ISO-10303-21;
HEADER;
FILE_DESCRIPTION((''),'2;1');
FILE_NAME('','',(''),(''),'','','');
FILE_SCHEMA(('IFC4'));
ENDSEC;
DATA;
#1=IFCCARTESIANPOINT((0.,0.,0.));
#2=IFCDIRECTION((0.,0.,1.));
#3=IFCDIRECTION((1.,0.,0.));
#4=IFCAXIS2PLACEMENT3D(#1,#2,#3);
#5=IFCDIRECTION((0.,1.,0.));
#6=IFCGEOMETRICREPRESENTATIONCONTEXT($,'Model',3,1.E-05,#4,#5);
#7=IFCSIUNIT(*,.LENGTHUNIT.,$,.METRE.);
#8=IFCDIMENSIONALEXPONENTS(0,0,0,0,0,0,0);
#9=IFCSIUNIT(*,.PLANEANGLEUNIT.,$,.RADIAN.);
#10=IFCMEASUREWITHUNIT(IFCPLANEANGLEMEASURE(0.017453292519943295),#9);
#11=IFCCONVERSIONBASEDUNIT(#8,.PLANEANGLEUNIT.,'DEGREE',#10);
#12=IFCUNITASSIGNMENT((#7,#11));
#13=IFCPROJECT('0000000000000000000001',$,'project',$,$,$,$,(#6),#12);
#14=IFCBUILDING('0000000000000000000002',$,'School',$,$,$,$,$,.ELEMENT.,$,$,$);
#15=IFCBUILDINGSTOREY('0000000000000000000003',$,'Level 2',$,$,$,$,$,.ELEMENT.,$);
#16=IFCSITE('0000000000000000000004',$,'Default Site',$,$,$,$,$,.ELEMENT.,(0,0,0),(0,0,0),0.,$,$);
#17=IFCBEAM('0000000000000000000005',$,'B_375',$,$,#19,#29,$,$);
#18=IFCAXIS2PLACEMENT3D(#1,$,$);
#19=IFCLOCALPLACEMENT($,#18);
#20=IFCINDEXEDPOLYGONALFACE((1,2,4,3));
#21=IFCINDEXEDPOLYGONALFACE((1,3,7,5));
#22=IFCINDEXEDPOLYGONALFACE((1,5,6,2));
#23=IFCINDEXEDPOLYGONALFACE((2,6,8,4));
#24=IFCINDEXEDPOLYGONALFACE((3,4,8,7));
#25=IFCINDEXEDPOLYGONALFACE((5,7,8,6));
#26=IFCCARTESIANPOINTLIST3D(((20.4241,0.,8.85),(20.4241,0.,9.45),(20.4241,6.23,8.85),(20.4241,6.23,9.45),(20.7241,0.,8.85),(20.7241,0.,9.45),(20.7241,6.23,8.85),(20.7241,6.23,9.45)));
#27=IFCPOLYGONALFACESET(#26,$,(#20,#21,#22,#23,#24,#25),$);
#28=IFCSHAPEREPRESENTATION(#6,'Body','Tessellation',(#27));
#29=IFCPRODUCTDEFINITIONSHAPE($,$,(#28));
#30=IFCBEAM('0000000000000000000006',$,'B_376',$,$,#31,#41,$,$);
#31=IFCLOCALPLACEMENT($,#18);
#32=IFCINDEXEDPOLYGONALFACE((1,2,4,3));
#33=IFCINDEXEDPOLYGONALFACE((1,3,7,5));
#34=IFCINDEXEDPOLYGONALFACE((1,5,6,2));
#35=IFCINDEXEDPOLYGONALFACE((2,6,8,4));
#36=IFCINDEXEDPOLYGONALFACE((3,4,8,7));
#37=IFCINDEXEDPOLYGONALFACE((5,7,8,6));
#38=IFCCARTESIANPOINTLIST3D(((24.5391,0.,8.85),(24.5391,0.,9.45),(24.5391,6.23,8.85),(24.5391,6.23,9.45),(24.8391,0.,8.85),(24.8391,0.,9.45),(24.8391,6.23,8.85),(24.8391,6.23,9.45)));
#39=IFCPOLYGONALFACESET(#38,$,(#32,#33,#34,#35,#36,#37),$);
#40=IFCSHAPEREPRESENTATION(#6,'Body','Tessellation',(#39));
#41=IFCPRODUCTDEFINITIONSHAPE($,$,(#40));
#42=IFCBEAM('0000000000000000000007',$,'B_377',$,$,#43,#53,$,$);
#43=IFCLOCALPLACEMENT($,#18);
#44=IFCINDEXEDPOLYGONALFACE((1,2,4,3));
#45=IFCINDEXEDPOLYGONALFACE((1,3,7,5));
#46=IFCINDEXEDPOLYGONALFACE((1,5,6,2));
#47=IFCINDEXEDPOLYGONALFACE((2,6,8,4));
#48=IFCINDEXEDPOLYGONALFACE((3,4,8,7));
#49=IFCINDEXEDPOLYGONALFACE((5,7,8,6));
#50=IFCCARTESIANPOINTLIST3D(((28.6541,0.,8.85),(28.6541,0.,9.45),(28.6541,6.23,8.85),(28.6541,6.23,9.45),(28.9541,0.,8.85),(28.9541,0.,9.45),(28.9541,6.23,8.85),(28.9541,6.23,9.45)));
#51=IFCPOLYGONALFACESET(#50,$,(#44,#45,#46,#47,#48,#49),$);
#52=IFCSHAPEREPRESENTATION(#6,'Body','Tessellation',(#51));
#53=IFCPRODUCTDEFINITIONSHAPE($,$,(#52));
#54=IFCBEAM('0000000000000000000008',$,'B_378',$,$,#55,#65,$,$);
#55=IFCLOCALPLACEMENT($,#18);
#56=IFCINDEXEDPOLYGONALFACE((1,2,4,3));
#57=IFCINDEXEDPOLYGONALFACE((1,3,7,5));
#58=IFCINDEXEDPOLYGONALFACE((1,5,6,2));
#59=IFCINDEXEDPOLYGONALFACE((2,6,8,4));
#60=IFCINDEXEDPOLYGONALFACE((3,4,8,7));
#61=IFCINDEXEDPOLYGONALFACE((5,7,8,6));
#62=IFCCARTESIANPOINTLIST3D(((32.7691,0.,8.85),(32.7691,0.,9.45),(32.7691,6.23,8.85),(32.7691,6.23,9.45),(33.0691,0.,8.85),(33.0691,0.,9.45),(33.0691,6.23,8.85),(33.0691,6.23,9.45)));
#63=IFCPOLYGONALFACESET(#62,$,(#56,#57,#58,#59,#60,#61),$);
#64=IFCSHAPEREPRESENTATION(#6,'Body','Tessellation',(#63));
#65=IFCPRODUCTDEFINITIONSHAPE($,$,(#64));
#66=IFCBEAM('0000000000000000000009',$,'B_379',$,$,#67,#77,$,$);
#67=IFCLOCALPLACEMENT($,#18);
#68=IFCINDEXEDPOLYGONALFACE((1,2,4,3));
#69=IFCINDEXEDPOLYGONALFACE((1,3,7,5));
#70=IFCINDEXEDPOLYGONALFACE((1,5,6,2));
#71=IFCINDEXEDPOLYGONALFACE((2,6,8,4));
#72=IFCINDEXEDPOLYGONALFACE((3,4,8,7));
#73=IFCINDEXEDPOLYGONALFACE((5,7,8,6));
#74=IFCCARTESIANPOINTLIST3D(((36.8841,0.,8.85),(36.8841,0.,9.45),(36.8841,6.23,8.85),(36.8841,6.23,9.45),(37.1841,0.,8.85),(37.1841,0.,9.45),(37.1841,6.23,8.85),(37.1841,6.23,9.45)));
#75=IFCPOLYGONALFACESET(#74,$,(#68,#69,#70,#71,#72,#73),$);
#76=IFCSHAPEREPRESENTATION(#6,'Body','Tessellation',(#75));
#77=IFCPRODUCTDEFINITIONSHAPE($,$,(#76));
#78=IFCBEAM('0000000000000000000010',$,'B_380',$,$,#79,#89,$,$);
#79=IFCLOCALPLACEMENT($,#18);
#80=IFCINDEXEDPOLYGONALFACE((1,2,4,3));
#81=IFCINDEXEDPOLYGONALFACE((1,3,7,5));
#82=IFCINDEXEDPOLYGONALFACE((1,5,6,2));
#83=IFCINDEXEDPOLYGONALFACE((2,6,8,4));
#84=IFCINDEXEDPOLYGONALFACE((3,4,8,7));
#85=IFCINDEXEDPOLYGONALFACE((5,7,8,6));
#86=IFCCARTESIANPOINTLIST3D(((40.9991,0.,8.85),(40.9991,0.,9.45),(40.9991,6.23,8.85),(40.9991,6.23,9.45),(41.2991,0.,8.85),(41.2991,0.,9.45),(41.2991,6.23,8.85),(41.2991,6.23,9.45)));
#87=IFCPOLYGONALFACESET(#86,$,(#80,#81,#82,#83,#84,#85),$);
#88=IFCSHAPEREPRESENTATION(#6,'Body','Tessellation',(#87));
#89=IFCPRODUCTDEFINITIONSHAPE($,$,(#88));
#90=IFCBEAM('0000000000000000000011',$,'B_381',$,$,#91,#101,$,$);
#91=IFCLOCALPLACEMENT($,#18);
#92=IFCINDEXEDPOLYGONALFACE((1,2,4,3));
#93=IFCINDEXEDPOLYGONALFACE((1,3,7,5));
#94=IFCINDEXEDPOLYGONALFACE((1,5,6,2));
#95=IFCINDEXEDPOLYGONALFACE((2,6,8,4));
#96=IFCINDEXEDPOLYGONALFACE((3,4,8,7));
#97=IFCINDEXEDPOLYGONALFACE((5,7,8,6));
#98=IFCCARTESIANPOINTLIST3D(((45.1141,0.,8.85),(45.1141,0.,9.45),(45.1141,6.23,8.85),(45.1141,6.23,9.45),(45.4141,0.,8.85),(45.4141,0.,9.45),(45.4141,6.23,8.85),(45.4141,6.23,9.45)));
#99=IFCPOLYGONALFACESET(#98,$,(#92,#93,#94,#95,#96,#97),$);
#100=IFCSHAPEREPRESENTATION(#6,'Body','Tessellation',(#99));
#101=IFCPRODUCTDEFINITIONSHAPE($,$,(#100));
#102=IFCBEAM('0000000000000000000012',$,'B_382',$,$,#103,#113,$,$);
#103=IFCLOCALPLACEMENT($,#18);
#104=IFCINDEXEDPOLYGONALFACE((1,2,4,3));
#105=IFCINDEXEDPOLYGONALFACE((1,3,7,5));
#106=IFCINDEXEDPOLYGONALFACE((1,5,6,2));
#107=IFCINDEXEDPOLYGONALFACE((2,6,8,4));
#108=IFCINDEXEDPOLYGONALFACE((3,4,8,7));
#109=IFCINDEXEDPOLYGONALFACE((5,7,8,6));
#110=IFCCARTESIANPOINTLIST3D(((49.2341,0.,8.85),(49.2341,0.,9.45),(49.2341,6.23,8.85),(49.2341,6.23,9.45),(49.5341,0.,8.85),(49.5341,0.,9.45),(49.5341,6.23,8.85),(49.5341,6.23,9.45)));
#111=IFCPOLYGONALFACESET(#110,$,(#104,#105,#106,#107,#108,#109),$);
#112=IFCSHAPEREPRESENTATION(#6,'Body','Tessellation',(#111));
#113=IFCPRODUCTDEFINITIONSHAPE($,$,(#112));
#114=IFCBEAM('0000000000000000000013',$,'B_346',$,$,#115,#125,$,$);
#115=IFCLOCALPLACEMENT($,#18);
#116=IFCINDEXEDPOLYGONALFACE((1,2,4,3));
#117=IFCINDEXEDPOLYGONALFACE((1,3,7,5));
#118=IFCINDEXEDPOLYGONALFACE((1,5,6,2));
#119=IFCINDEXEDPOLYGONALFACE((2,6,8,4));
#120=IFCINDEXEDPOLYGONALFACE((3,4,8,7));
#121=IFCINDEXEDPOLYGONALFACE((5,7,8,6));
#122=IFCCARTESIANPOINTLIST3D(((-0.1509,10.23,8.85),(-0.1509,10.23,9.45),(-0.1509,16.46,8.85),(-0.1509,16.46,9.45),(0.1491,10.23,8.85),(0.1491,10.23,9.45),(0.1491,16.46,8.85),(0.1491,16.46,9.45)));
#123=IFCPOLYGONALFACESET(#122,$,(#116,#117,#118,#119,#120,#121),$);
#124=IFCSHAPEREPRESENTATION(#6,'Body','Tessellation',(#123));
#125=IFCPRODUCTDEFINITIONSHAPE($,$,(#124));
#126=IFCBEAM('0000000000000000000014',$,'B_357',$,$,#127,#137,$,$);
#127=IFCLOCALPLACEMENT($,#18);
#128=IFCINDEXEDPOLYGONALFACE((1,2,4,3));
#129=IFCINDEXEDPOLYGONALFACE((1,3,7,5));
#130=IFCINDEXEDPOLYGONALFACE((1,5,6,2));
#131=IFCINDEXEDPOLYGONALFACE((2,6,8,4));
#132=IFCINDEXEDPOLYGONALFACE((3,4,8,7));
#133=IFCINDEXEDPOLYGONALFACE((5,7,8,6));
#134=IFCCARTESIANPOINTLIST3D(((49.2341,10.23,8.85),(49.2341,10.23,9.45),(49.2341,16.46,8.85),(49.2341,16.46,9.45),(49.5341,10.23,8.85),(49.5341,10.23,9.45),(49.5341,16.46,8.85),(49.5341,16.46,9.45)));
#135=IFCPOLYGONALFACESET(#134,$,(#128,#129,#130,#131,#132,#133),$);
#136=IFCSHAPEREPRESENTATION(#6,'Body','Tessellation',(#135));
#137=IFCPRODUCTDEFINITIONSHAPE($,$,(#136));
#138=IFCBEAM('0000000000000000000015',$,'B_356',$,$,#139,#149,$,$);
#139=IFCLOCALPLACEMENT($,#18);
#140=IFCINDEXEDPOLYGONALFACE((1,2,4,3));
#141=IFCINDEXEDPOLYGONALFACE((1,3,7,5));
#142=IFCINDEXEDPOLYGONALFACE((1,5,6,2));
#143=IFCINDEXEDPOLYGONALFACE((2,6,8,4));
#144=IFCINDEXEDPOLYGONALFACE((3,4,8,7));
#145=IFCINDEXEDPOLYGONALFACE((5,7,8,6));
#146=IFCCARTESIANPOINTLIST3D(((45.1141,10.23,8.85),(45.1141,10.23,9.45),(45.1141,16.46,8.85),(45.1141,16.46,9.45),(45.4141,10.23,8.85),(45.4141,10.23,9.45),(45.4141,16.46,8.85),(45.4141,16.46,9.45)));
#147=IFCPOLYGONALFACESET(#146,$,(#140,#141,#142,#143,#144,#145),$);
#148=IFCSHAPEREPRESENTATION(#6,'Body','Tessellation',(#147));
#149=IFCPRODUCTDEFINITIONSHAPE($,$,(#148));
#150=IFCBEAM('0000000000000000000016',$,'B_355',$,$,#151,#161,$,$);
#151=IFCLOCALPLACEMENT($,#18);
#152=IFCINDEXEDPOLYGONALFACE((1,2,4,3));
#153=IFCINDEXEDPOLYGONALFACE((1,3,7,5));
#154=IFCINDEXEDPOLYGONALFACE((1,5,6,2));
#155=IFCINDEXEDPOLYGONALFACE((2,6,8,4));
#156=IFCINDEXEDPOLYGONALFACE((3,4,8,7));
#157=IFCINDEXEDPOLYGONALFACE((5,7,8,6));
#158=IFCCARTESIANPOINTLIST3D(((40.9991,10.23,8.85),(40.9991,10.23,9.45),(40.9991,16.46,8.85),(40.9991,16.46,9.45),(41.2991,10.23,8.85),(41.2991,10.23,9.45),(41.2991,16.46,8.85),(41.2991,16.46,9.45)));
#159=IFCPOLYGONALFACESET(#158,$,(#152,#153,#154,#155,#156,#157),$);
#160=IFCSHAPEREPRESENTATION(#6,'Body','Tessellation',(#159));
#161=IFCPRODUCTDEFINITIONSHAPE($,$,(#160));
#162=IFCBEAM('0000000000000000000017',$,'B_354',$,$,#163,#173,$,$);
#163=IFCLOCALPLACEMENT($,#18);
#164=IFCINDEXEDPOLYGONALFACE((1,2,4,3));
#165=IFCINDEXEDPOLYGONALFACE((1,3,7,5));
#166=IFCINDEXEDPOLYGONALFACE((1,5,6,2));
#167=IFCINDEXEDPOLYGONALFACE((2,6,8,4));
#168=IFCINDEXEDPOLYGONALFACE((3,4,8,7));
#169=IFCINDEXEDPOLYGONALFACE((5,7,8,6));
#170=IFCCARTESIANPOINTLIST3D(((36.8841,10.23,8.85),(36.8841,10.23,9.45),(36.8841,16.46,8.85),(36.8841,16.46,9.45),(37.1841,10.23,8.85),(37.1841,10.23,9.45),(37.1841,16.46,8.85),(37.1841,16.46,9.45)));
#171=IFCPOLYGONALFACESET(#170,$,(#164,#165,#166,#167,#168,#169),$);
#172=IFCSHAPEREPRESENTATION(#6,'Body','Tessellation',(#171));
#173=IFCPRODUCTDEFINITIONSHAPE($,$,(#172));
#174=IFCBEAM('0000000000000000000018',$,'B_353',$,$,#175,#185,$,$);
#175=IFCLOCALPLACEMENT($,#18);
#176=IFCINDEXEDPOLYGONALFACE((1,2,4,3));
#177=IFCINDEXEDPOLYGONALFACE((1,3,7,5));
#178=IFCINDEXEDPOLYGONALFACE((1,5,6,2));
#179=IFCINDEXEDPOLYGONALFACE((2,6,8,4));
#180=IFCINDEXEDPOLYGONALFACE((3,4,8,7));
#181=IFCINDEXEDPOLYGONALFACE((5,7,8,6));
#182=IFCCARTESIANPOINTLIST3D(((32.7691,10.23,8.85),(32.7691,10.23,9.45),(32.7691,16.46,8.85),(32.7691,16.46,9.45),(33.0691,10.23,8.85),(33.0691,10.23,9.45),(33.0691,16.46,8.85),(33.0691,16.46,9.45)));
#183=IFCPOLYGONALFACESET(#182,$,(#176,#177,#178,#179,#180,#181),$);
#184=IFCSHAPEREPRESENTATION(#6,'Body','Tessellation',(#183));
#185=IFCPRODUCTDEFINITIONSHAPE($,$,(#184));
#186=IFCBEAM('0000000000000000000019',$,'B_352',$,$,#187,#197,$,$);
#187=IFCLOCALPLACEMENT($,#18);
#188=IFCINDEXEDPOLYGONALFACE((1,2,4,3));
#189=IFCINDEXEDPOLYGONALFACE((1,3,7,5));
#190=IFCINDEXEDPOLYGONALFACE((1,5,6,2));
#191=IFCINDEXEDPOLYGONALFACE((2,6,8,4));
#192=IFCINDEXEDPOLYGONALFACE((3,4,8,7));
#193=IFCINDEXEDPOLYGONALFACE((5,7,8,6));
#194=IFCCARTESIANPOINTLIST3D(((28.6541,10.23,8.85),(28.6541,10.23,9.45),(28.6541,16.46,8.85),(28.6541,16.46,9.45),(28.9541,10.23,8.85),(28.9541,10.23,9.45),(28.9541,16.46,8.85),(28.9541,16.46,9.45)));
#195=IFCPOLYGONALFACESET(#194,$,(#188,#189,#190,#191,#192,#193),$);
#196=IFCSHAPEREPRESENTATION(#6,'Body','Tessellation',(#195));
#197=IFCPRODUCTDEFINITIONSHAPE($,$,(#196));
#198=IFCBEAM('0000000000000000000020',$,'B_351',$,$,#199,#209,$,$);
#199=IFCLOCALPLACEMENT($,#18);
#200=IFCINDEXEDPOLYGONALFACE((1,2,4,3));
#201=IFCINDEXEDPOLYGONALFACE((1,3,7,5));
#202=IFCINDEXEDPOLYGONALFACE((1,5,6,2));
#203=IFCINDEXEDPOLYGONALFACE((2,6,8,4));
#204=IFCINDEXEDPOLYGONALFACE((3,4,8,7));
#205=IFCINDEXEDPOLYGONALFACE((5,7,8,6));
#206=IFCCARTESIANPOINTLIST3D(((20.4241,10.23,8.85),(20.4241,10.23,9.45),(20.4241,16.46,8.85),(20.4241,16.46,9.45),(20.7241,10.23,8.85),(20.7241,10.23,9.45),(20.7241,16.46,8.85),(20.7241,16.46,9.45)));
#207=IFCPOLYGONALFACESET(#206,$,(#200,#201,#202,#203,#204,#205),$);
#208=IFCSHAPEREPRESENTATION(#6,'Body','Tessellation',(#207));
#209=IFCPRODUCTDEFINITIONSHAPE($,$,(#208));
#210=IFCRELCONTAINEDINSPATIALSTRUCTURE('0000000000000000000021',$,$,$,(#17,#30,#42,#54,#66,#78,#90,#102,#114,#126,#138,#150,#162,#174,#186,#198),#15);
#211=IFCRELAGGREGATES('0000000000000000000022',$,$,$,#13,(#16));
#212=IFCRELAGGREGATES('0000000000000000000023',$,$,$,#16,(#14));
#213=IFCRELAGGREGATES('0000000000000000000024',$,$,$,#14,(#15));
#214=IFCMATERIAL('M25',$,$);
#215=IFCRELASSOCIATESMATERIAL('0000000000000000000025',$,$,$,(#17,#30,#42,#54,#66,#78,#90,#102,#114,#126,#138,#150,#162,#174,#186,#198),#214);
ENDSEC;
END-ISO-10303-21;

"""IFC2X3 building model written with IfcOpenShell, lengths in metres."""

from ifc_helpers import new_model, entity, si_unit, converted_unit, direction, frame, frame_2d, origin_with_axes, place, context, project, spatial, rectangle, extrude, material, element, save


model = new_model("IFC2X3")

# Units and contexts
model_context = context("Model", 3, precision=1e-05, world=origin_with_axes(), true_north=direction((0.0, 1.0, 0.0)))
ifc_project = project(units=[si_unit("LENGTHUNIT", "METRE"), converted_unit("PLANEANGLEUNIT", "DEGREE", entity("IfcPlaneAngleMeasure", 0.017453292519943295), si_unit("PLANEANGLEUNIT", "RADIAN"), dimensions=[0, 0, 0, 0, 0, 0, 0])], contexts=[model_context])

# Site, building, storey
site = spatial("IfcSite", under=ifc_project, Name="Default Site", CompositionType="ELEMENT", RefLatitude=(0, 0, 0), RefLongitude=(0, 0, 0), RefElevation=0.0)
building = spatial("IfcBuilding", under=site, Name="School", CompositionType="ELEMENT")
storey = spatial("IfcBuildingStorey", under=building, Name="Level 2", CompositionType="ELEMENT")

# Beams
ifc_material = material(Name="M25")
placement = place(None, origin_with_axes())
element("IfcBeam", 1, at=placement, inside=storey, material=ifc_material, Name="B_375", context=model_context, shape_type="SweptSolid", body=[
    extrude(rectangle(XDim=0.3, YDim=0.6, at=frame_2d((0.0, 0.0), x_axis=(0.0, 1.0, 0.0))), frame((20.5741, 0.0, 9.15), z_axis=(0.0, 1.0, 0.0), x_axis=(0.0, 0.0, -1.0)), (0.0, 0.0, 1.0), 6.23),
])
element("IfcBeam", 2, at=placement, inside=storey, material=ifc_material, Name="B_376", context=model_context, shape_type="SweptSolid", body=[
    extrude(rectangle(XDim=0.3, YDim=0.6, at=frame_2d((0.0, 0.0), x_axis=(0.0, 1.0, 0.0))), frame((24.6891, 0.0, 9.15), z_axis=(0.0, 1.0, 0.0), x_axis=(0.0, 0.0, -1.0)), (0.0, 0.0, 1.0), 6.23),
])
element("IfcBeam", 3, at=placement, inside=storey, material=ifc_material, Name="B_377", context=model_context, shape_type="SweptSolid", body=[
    extrude(rectangle(XDim=0.3, YDim=0.6, at=frame_2d((0.0, 0.0), x_axis=(0.0, 1.0, 0.0))), frame((28.8041, 0.0, 9.15), z_axis=(0.0, 1.0, 0.0), x_axis=(0.0, 0.0, -1.0)), (0.0, 0.0, 1.0), 6.23),
])
element("IfcBeam", 4, at=placement, inside=storey, material=ifc_material, Name="B_378", context=model_context, shape_type="SweptSolid", body=[
    extrude(rectangle(XDim=0.3, YDim=0.6, at=frame_2d((0.0, 0.0), x_axis=(0.0, 1.0, 0.0))), frame((32.9191, 0.0, 9.15), z_axis=(0.0, 1.0, 0.0), x_axis=(0.0, 0.0, -1.0)), (0.0, 0.0, 1.0), 6.23),
])
element("IfcBeam", 5, at=placement, inside=storey, material=ifc_material, Name="B_379", context=model_context, shape_type="SweptSolid", body=[
    extrude(rectangle(XDim=0.3, YDim=0.6, at=frame_2d((0.0, 0.0), x_axis=(0.0, 1.0, 0.0))), frame((37.0341, 0.0, 9.15), z_axis=(0.0, 1.0, 0.0), x_axis=(0.0, 0.0, -1.0)), (0.0, 0.0, 1.0), 6.23),
])
element("IfcBeam", 6, at=placement, inside=storey, material=ifc_material, Name="B_380", context=model_context, shape_type="SweptSolid", body=[
    extrude(rectangle(XDim=0.3, YDim=0.6, at=frame_2d((0.0, 0.0), x_axis=(0.0, 1.0, 0.0))), frame((41.1491, 0.0, 9.15), z_axis=(0.0, 1.0, 0.0), x_axis=(0.0, 0.0, -1.0)), (0.0, 0.0, 1.0), 6.23),
])
element("IfcBeam", 7, at=placement, inside=storey, material=ifc_material, Name="B_381", context=model_context, shape_type="SweptSolid", body=[
    extrude(rectangle(XDim=0.3, YDim=0.6, at=frame_2d((0.0, 0.0), x_axis=(0.0, 1.0, 0.0))), frame((45.2641, 0.0, 9.15), z_axis=(0.0, 1.0, 0.0), x_axis=(0.0, 0.0, -1.0)), (0.0, 0.0, 1.0), 6.23),
])
element("IfcBeam", 8, at=placement, inside=storey, material=ifc_material, Name="B_382", context=model_context, shape_type="SweptSolid", body=[
    extrude(rectangle(XDim=0.3, YDim=0.6, at=frame_2d((0.0, 0.0), x_axis=(0.0, 1.0, 0.0))), frame((49.3841, 0.0, 9.15), z_axis=(0.0, 1.0, 0.0), x_axis=(0.0, 0.0, -1.0)), (0.0, 0.0, 1.0), 6.23),
])
element("IfcBeam", 9, at=placement, inside=storey, material=ifc_material, Name="B_346", context=model_context, shape_type="SweptSolid", body=[
    extrude(rectangle(XDim=0.3, YDim=0.6, at=frame_2d((0.0, 0.0), x_axis=(0.0, 1.0, 0.0))), frame((-0.0009, 10.23, 9.15), z_axis=(0.0, 1.0, 0.0), x_axis=(0.0, 0.0, -1.0)), (0.0, 0.0, 1.0), 6.23),
])
element("IfcBeam", 10, at=placement, inside=storey, material=ifc_material, Name="B_357", context=model_context, shape_type="SweptSolid", body=[
    extrude(rectangle(XDim=0.3, YDim=0.6, at=frame_2d((0.0, 0.0), x_axis=(0.0, 1.0, 0.0))), frame((49.3841, 10.23, 9.15), z_axis=(0.0, 1.0, 0.0), x_axis=(0.0, 0.0, -1.0)), (0.0, 0.0, 1.0), 6.23),
])
element("IfcBeam", 11, at=placement, inside=storey, material=ifc_material, Name="B_356", context=model_context, shape_type="SweptSolid", body=[
    extrude(rectangle(XDim=0.3, YDim=0.6, at=frame_2d((0.0, 0.0), x_axis=(0.0, 1.0, 0.0))), frame((45.2641, 10.23, 9.15), z_axis=(0.0, 1.0, 0.0), x_axis=(0.0, 0.0, -1.0)), (0.0, 0.0, 1.0), 6.23),
])
element("IfcBeam", 12, at=placement, inside=storey, material=ifc_material, Name="B_355", context=model_context, shape_type="SweptSolid", body=[
    extrude(rectangle(XDim=0.3, YDim=0.6, at=frame_2d((0.0, 0.0), x_axis=(0.0, 1.0, 0.0))), frame((41.1491, 10.23, 9.15), z_axis=(0.0, 1.0, 0.0), x_axis=(0.0, 0.0, -1.0)), (0.0, 0.0, 1.0), 6.23),
])
element("IfcBeam", 13, at=placement, inside=storey, material=ifc_material, Name="B_354", context=model_context, shape_type="SweptSolid", body=[
    extrude(rectangle(XDim=0.3, YDim=0.6, at=frame_2d((0.0, 0.0), x_axis=(0.0, 1.0, 0.0))), frame((37.0341, 10.23, 9.15), z_axis=(0.0, 1.0, 0.0), x_axis=(0.0, 0.0, -1.0)), (0.0, 0.0, 1.0), 6.23),
])
element("IfcBeam", 14, at=placement, inside=storey, material=ifc_material, Name="B_353", context=model_context, shape_type="SweptSolid", body=[
    extrude(rectangle(XDim=0.3, YDim=0.6, at=frame_2d((0.0, 0.0), x_axis=(0.0, 1.0, 0.0))), frame((32.9191, 10.23, 9.15), z_axis=(0.0, 1.0, 0.0), x_axis=(0.0, 0.0, -1.0)), (0.0, 0.0, 1.0), 6.23),
])
element("IfcBeam", 15, at=placement, inside=storey, material=ifc_material, Name="B_352", context=model_context, shape_type="SweptSolid", body=[
    extrude(rectangle(XDim=0.3, YDim=0.6, at=frame_2d((0.0, 0.0), x_axis=(0.0, 1.0, 0.0))), frame((28.8041, 10.23, 9.15), z_axis=(0.0, 1.0, 0.0), x_axis=(0.0, 0.0, -1.0)), (0.0, 0.0, 1.0), 6.23),
])
element("IfcBeam", 16, at=placement, inside=storey, material=ifc_material, Name="B_351", context=model_context, shape_type="SweptSolid", body=[
    extrude(rectangle(XDim=0.3, YDim=0.6, at=frame_2d((0.0, 0.0), x_axis=(0.0, 1.0, 0.0))), frame((20.5741, 10.23, 9.15), z_axis=(0.0, 1.0, 0.0), x_axis=(0.0, 0.0, -1.0)), (0.0, 0.0, 1.0), 6.23),
])

save(model, "model.ifc")
